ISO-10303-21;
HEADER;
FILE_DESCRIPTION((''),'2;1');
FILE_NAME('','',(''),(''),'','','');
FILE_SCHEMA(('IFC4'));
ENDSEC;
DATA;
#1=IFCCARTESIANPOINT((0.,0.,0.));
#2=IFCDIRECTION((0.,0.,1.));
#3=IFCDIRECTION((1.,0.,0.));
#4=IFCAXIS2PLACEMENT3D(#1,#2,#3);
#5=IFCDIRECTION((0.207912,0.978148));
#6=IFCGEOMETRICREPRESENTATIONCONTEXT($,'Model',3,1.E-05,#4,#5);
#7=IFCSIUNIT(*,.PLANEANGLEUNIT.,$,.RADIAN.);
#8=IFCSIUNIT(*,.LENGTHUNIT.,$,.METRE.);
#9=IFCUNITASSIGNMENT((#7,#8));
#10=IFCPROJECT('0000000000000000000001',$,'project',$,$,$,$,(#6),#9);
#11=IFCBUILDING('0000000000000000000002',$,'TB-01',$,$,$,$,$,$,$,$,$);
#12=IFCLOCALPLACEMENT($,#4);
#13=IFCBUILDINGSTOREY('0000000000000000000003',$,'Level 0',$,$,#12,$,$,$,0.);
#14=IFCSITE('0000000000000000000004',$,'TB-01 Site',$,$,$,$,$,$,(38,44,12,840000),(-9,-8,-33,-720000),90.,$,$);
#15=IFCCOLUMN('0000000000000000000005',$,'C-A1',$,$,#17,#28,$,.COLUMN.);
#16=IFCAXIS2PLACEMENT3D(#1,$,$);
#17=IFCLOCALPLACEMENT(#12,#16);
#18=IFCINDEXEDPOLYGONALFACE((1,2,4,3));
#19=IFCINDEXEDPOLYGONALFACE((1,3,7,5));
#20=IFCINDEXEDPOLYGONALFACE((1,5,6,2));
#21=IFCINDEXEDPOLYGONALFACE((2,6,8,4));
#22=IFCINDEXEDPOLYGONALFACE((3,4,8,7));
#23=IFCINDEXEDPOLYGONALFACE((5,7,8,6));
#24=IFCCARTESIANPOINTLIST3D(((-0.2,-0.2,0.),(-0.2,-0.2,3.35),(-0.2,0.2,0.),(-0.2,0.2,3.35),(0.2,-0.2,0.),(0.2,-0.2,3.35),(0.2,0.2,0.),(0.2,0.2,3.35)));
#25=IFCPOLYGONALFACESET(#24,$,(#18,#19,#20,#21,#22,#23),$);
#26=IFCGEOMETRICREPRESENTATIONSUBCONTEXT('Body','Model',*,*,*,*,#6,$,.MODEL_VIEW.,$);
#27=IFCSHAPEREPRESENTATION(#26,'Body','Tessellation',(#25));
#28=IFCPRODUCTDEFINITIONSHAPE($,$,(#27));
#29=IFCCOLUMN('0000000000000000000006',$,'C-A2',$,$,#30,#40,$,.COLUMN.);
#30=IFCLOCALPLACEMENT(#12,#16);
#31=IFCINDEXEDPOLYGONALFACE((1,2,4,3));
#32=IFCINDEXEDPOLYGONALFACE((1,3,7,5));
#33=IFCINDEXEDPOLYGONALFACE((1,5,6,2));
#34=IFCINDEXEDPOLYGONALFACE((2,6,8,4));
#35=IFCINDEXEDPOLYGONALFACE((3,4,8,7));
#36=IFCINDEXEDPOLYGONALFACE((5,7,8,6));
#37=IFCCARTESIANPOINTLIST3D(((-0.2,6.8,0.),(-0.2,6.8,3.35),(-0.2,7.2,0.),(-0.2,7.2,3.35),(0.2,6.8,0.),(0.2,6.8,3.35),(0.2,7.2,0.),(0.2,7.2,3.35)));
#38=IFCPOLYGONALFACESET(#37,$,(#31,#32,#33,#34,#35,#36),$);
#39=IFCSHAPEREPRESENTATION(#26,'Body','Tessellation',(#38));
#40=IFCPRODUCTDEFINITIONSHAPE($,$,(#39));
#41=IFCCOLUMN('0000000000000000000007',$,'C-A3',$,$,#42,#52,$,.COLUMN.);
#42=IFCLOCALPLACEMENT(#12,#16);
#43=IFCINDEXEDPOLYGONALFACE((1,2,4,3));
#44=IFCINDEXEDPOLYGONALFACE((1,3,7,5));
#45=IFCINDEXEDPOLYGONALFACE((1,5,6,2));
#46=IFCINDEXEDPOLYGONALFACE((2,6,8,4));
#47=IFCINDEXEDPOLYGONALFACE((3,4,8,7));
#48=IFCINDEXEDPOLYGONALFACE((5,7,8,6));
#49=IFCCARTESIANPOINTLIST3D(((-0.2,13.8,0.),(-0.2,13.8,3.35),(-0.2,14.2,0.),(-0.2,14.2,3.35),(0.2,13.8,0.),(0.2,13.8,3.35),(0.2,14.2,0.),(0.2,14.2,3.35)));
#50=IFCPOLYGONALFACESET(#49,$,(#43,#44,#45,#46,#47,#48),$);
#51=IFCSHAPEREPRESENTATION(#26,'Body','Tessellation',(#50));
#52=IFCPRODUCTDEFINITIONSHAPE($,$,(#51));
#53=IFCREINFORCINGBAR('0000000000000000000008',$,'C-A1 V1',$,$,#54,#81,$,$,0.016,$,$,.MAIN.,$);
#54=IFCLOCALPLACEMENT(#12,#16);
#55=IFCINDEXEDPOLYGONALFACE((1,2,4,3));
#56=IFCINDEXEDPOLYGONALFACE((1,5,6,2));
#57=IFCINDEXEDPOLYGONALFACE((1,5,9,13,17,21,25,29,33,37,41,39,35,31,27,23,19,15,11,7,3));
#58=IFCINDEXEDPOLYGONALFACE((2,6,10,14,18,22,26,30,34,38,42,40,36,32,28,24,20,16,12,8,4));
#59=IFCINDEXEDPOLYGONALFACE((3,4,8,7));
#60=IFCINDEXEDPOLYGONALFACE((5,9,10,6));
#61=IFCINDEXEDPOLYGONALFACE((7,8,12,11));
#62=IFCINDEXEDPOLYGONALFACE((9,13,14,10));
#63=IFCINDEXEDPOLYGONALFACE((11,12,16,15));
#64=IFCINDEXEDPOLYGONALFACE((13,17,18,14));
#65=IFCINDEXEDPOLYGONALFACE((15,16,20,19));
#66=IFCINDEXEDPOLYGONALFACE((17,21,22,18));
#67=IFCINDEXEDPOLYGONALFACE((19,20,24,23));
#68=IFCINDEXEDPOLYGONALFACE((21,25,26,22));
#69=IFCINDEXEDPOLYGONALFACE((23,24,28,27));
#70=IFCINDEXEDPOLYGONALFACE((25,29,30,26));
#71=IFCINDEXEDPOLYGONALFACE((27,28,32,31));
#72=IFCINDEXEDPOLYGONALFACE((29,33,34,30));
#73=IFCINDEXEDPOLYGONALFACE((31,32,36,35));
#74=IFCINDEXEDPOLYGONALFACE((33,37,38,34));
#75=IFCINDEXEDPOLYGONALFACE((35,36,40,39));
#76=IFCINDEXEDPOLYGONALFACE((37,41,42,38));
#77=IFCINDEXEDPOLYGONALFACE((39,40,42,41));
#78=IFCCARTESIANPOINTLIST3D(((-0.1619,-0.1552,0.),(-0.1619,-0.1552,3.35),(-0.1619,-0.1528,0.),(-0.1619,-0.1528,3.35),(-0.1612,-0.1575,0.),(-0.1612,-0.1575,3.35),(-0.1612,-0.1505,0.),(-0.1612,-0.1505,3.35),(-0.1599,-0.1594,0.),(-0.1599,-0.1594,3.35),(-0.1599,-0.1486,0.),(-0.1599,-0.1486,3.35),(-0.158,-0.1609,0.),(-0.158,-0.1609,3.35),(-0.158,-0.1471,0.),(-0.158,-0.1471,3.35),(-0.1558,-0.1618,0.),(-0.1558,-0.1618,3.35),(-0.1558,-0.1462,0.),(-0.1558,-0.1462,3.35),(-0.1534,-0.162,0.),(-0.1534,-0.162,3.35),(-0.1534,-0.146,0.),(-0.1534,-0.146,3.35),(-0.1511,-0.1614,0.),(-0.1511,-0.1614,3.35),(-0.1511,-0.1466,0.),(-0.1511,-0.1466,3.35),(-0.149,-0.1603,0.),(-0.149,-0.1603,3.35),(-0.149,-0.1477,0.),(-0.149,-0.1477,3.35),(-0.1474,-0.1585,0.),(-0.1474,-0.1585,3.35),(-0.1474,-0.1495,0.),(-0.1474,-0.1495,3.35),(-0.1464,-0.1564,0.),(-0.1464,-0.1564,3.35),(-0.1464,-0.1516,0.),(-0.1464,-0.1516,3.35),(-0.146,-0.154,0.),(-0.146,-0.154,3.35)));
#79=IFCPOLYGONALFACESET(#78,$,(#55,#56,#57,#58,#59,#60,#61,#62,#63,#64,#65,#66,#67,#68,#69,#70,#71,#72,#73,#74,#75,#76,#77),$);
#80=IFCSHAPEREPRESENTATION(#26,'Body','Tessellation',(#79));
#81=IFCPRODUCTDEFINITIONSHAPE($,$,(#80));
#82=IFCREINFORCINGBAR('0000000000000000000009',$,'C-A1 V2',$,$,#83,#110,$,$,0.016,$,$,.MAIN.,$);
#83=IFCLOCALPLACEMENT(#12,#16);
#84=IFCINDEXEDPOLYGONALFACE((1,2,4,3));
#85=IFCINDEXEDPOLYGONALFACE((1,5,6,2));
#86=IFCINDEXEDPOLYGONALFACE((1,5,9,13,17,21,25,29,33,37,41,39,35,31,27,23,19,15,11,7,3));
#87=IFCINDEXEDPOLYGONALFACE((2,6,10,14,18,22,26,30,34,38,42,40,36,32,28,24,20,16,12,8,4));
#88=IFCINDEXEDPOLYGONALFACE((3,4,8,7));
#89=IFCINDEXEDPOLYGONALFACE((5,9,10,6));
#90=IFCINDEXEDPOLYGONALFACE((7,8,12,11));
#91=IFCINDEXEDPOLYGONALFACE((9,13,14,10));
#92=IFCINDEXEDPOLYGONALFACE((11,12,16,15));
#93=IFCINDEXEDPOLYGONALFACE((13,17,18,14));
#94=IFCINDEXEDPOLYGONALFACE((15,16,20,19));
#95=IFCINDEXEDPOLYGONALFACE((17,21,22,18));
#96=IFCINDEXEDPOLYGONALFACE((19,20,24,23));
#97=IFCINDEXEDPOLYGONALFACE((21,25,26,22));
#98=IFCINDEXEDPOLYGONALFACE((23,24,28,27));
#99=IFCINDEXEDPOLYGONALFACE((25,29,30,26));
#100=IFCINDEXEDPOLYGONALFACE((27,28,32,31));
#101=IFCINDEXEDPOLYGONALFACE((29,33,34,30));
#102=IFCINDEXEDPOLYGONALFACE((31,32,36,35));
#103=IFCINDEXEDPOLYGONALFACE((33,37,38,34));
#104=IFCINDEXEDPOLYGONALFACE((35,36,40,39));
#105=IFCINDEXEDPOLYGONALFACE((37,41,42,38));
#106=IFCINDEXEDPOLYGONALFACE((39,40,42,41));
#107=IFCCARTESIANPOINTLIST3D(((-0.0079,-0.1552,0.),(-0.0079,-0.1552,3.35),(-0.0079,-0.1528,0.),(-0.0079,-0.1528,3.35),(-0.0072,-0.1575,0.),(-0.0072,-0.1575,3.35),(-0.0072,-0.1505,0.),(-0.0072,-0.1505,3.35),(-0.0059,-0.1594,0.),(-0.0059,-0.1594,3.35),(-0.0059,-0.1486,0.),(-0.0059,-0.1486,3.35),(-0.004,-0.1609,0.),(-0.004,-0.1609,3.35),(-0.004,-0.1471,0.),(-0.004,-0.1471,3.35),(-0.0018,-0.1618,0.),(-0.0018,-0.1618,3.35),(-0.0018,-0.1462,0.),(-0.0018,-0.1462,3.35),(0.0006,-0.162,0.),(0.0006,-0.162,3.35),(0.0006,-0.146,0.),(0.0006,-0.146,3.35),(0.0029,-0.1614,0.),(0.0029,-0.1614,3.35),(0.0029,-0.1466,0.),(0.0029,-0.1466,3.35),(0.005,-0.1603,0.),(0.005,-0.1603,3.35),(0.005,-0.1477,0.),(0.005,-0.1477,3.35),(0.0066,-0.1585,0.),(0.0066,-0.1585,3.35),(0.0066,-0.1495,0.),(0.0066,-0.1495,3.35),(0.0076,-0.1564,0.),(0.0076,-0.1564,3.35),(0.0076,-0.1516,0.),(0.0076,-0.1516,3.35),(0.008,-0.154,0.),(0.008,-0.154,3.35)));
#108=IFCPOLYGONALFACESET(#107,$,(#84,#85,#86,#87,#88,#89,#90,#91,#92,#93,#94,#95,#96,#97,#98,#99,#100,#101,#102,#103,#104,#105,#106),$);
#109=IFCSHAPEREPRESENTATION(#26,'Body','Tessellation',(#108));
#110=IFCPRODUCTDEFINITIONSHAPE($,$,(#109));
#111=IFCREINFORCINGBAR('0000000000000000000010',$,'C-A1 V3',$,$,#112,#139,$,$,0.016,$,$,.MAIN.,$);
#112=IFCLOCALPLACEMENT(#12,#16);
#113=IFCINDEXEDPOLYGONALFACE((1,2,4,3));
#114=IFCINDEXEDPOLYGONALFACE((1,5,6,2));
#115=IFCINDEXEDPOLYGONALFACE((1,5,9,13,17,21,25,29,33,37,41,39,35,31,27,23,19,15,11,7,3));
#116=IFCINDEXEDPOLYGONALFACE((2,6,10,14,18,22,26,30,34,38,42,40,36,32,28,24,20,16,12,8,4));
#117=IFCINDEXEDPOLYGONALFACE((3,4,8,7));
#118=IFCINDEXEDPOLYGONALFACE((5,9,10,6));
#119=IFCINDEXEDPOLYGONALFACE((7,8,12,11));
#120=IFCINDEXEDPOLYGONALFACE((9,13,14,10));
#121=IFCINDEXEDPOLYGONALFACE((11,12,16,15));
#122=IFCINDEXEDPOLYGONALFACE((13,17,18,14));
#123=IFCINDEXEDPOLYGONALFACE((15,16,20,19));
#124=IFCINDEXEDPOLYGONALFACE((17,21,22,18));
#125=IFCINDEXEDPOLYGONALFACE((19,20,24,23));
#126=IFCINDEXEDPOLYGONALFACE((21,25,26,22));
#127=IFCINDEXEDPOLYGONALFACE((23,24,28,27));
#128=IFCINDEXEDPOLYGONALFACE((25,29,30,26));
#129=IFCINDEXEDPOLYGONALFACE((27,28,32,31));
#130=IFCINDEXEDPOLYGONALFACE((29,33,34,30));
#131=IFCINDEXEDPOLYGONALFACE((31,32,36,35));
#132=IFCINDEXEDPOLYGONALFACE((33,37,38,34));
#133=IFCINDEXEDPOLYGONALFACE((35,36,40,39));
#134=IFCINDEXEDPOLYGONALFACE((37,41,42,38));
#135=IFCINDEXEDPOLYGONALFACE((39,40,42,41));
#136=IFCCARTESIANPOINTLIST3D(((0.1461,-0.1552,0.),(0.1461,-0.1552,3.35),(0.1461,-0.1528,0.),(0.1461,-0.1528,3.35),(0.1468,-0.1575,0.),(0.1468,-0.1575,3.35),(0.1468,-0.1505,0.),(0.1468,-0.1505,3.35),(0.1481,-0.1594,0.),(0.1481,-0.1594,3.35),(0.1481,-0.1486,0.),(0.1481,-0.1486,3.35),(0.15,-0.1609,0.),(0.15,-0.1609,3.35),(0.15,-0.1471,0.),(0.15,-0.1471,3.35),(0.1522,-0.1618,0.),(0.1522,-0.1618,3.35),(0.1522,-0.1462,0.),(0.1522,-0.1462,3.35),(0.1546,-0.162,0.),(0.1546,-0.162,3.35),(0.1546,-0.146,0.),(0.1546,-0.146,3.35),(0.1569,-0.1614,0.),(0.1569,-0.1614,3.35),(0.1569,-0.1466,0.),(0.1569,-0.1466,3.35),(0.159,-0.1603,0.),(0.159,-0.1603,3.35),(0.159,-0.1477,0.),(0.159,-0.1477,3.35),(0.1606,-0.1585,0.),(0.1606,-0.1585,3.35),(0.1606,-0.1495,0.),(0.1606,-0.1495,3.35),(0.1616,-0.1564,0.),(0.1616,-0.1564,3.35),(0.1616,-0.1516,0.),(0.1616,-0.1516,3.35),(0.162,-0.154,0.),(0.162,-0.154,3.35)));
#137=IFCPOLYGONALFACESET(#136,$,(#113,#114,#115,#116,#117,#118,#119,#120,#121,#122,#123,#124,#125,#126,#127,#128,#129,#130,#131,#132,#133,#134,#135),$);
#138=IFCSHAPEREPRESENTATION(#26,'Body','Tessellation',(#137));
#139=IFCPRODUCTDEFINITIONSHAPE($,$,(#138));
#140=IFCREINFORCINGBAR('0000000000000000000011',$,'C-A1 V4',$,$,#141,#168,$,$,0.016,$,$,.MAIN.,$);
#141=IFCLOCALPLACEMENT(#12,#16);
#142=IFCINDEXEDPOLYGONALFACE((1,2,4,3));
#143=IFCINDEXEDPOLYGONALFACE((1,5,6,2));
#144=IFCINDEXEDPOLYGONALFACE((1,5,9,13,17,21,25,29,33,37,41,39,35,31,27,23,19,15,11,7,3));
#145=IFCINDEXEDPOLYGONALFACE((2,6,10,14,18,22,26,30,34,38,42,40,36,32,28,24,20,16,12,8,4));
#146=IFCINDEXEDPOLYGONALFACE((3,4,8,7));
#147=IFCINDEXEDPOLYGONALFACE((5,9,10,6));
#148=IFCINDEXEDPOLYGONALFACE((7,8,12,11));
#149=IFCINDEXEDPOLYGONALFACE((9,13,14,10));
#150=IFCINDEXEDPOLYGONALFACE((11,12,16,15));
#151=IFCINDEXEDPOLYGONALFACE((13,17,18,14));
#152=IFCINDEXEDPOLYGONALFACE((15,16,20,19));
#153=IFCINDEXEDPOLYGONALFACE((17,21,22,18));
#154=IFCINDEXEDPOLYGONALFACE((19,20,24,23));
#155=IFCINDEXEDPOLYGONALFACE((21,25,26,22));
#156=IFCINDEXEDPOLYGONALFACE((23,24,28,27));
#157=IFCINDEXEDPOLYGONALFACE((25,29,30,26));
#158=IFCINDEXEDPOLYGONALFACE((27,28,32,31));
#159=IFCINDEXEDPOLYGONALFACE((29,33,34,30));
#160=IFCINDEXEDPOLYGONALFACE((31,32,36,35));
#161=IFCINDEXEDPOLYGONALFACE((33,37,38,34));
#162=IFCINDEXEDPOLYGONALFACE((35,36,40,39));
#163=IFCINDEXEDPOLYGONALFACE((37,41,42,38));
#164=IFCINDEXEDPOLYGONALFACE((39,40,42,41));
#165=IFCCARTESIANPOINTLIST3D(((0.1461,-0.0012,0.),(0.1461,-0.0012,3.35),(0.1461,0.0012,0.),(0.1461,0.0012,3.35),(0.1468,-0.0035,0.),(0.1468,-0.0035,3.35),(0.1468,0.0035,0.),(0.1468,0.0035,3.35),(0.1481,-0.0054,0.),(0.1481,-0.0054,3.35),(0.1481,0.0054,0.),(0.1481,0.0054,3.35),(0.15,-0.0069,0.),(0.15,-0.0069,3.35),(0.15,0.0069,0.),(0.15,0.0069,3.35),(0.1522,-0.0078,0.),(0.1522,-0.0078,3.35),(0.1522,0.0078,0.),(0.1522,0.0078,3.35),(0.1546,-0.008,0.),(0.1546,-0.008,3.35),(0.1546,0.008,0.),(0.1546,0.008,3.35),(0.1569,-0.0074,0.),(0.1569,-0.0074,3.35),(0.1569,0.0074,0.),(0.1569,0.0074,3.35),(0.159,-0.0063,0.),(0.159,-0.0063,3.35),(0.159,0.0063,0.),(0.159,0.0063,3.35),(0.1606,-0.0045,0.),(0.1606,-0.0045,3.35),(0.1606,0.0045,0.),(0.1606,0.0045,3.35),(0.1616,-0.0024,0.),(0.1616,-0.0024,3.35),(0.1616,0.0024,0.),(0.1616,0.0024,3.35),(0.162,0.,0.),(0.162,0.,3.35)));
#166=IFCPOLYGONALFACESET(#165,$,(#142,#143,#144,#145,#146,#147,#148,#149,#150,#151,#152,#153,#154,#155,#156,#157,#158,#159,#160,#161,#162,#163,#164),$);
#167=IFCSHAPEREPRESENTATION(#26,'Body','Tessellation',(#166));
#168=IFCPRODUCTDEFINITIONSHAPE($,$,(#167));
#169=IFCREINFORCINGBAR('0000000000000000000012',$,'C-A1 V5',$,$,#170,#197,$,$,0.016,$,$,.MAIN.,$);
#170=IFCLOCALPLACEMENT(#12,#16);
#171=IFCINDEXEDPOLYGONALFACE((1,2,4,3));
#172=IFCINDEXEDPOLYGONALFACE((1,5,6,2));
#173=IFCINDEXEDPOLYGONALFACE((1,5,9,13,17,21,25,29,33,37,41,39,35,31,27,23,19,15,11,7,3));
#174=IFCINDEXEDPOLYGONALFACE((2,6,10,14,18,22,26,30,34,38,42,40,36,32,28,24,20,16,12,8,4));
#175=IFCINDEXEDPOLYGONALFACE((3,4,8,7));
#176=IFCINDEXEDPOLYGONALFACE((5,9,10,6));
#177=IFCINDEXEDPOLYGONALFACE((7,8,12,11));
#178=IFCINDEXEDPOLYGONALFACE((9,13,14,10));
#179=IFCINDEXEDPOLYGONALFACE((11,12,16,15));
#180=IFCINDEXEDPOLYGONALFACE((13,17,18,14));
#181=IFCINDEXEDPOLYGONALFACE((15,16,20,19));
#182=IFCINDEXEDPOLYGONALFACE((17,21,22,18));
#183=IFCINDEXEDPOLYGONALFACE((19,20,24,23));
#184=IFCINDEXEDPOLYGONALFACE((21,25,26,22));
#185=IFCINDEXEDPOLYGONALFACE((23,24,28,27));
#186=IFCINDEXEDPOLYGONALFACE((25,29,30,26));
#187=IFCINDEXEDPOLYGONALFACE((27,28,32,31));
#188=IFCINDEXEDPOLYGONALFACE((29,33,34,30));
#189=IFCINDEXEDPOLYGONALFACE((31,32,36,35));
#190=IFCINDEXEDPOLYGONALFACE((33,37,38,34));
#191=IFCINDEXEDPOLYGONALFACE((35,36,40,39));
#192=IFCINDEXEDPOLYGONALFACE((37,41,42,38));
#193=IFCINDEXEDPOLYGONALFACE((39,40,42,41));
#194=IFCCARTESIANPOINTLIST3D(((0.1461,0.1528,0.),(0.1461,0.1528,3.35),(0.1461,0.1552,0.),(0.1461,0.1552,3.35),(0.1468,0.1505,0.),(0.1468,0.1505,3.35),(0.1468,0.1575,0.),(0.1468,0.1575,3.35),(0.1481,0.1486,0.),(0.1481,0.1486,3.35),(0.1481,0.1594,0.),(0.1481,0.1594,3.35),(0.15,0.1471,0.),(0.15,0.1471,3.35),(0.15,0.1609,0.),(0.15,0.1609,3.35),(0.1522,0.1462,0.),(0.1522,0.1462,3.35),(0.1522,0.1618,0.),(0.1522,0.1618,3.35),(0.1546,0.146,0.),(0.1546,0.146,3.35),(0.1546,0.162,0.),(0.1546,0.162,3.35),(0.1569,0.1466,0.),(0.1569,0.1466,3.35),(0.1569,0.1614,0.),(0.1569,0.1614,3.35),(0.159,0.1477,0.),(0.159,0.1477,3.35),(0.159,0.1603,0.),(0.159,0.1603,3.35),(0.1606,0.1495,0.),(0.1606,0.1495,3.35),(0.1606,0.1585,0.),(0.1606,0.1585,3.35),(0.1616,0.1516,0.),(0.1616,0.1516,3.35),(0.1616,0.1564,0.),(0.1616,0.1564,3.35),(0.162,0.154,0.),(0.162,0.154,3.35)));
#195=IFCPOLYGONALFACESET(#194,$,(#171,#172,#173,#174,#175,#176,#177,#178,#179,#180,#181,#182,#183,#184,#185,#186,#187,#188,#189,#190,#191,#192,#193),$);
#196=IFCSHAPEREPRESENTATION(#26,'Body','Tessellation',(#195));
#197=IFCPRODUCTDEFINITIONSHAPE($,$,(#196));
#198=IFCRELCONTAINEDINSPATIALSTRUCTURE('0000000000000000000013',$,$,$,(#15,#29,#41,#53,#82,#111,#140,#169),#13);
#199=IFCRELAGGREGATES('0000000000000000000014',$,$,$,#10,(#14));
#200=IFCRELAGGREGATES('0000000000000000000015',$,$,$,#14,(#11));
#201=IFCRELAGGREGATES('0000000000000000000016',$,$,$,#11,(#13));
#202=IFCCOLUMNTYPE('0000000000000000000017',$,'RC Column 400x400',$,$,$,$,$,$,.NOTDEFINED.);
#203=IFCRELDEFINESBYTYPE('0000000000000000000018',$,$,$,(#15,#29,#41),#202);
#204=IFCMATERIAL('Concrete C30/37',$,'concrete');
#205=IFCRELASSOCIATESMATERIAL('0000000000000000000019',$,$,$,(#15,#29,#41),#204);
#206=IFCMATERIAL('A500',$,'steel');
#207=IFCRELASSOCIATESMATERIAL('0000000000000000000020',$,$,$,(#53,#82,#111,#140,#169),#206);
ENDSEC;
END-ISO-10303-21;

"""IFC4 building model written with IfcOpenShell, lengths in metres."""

from ifc_helpers import new_model, entity, si_unit, direction, frame, origin_with_axes, place, context, subcontext, project, spatial, rectangle, extrude, material, type_object, element, save


model = new_model("IFC4")

# Units and contexts
model_context = context("Model", 3, precision=1e-05, world=origin_with_axes(), true_north=direction((0.207912, 0.978148)))
body_context = subcontext(model_context, "Body", "Model", "MODEL_VIEW")
ifc_project = project(units=[si_unit("PLANEANGLEUNIT", "RADIAN"), si_unit("LENGTHUNIT", "METRE")], contexts=[model_context])

# Site, building, storey
site = spatial("IfcSite", under=ifc_project, Name="TB-01 Site", RefLatitude=(38, 44, 12, 840000), RefLongitude=(-9, -8, -33, -720000), RefElevation=90.0)
building = spatial("IfcBuilding", under=site, Name="TB-01")
storey_placement = place(None, origin_with_axes())
storey = spatial("IfcBuildingStorey", under=building, at=storey_placement, Name="Level 0", Elevation=0.0)

# Columns
ifc_material_1 = material(Name="Concrete C30/37", Category="concrete")
column_type = type_object("IfcColumnType", Name="RC Column 400x400", PredefinedType="NOTDEFINED")
column_1_placement = place(storey_placement, origin_with_axes())
element("IfcColumn", 1, at=column_1_placement, inside=storey, type_object=column_type, material=ifc_material_1, Name="C-A1", PredefinedType="COLUMN", context=body_context, shape_type="SweptSolid", body=[
    extrude(rectangle(XDim=0.4, YDim=0.4), origin_with_axes(), (0.0, 0.0, 1.0), 3.35),
])
column_2_placement = place(storey_placement, frame((0.0, 7.0, 0.0), z_axis=(0.0, 0.0, 1.0), x_axis=(1.0, 0.0, 0.0)))
element("IfcColumn", 2, at=column_2_placement, inside=storey, type_object=column_type, material=ifc_material_1, Name="C-A2", PredefinedType="COLUMN", context=body_context, shape_type="SweptSolid", body=[
    extrude(rectangle(XDim=0.4, YDim=0.4), origin_with_axes(), (0.0, 0.0, 1.0), 3.35),
])
column_3_placement = place(storey_placement, frame((0.0, 14.0, 0.0), z_axis=(0.0, 0.0, 1.0), x_axis=(1.0, 0.0, 0.0)))
element("IfcColumn", 3, at=column_3_placement, inside=storey, type_object=column_type, material=ifc_material_1, Name="C-A3", PredefinedType="COLUMN", context=body_context, shape_type="SweptSolid", body=[
    extrude(rectangle(XDim=0.4, YDim=0.4), origin_with_axes(), (0.0, 0.0, 1.0), 3.35),
])

# Reinforcing bars
ifc_material_2 = material(Name="A500", Category="steel")
reinforcing_bar_1_placement = place(storey_placement, origin_with_axes())
element("IfcReinforcingBar", 4, at=reinforcing_bar_1_placement, inside=storey, material=ifc_material_2, Name="C-A1 V1", NominalDiameter=0.016, PredefinedType="MAIN", context=body_context, shape_type="AdvancedSweptSolid", body=[
    entity("IfcSweptDiskSolid", entity("IfcPolyline", [entity("IfcCartesianPoint", [-0.154, -0.154, 0.0]), entity("IfcCartesianPoint", [-0.154, -0.154, 3.35])]), 0.008),
])
reinforcing_bar_2_placement = place(storey_placement, origin_with_axes())
element("IfcReinforcingBar", 5, at=reinforcing_bar_2_placement, inside=storey, material=ifc_material_2, Name="C-A1 V2", NominalDiameter=0.016, PredefinedType="MAIN", context=body_context, shape_type="AdvancedSweptSolid", body=[
    entity("IfcSweptDiskSolid", entity("IfcPolyline", [entity("IfcCartesianPoint", [0.0, -0.154, 0.0]), entity("IfcCartesianPoint", [0.0, -0.154, 3.35])]), 0.008),
])
reinforcing_bar_3_placement = place(storey_placement, origin_with_axes())
element("IfcReinforcingBar", 6, at=reinforcing_bar_3_placement, inside=storey, material=ifc_material_2, Name="C-A1 V3", NominalDiameter=0.016, PredefinedType="MAIN", context=body_context, shape_type="AdvancedSweptSolid", body=[
    entity("IfcSweptDiskSolid", entity("IfcPolyline", [entity("IfcCartesianPoint", [0.154, -0.154, 0.0]), entity("IfcCartesianPoint", [0.154, -0.154, 3.35])]), 0.008),
])
reinforcing_bar_4_placement = place(storey_placement, origin_with_axes())
element("IfcReinforcingBar", 7, at=reinforcing_bar_4_placement, inside=storey, material=ifc_material_2, Name="C-A1 V4", NominalDiameter=0.016, PredefinedType="MAIN", context=body_context, shape_type="AdvancedSweptSolid", body=[
    entity("IfcSweptDiskSolid", entity("IfcPolyline", [entity("IfcCartesianPoint", [0.154, 0.0, 0.0]), entity("IfcCartesianPoint", [0.154, 0.0, 3.35])]), 0.008),
])
reinforcing_bar_5_placement = place(storey_placement, origin_with_axes())
element("IfcReinforcingBar", 8, at=reinforcing_bar_5_placement, inside=storey, material=ifc_material_2, Name="C-A1 V5", NominalDiameter=0.016, PredefinedType="MAIN", context=body_context, shape_type="AdvancedSweptSolid", body=[
    entity("IfcSweptDiskSolid", entity("IfcPolyline", [entity("IfcCartesianPoint", [0.154, 0.154, 0.0]), entity("IfcCartesianPoint", [0.154, 0.154, 3.35])]), 0.008),
])

save(model, "model.ifc")
